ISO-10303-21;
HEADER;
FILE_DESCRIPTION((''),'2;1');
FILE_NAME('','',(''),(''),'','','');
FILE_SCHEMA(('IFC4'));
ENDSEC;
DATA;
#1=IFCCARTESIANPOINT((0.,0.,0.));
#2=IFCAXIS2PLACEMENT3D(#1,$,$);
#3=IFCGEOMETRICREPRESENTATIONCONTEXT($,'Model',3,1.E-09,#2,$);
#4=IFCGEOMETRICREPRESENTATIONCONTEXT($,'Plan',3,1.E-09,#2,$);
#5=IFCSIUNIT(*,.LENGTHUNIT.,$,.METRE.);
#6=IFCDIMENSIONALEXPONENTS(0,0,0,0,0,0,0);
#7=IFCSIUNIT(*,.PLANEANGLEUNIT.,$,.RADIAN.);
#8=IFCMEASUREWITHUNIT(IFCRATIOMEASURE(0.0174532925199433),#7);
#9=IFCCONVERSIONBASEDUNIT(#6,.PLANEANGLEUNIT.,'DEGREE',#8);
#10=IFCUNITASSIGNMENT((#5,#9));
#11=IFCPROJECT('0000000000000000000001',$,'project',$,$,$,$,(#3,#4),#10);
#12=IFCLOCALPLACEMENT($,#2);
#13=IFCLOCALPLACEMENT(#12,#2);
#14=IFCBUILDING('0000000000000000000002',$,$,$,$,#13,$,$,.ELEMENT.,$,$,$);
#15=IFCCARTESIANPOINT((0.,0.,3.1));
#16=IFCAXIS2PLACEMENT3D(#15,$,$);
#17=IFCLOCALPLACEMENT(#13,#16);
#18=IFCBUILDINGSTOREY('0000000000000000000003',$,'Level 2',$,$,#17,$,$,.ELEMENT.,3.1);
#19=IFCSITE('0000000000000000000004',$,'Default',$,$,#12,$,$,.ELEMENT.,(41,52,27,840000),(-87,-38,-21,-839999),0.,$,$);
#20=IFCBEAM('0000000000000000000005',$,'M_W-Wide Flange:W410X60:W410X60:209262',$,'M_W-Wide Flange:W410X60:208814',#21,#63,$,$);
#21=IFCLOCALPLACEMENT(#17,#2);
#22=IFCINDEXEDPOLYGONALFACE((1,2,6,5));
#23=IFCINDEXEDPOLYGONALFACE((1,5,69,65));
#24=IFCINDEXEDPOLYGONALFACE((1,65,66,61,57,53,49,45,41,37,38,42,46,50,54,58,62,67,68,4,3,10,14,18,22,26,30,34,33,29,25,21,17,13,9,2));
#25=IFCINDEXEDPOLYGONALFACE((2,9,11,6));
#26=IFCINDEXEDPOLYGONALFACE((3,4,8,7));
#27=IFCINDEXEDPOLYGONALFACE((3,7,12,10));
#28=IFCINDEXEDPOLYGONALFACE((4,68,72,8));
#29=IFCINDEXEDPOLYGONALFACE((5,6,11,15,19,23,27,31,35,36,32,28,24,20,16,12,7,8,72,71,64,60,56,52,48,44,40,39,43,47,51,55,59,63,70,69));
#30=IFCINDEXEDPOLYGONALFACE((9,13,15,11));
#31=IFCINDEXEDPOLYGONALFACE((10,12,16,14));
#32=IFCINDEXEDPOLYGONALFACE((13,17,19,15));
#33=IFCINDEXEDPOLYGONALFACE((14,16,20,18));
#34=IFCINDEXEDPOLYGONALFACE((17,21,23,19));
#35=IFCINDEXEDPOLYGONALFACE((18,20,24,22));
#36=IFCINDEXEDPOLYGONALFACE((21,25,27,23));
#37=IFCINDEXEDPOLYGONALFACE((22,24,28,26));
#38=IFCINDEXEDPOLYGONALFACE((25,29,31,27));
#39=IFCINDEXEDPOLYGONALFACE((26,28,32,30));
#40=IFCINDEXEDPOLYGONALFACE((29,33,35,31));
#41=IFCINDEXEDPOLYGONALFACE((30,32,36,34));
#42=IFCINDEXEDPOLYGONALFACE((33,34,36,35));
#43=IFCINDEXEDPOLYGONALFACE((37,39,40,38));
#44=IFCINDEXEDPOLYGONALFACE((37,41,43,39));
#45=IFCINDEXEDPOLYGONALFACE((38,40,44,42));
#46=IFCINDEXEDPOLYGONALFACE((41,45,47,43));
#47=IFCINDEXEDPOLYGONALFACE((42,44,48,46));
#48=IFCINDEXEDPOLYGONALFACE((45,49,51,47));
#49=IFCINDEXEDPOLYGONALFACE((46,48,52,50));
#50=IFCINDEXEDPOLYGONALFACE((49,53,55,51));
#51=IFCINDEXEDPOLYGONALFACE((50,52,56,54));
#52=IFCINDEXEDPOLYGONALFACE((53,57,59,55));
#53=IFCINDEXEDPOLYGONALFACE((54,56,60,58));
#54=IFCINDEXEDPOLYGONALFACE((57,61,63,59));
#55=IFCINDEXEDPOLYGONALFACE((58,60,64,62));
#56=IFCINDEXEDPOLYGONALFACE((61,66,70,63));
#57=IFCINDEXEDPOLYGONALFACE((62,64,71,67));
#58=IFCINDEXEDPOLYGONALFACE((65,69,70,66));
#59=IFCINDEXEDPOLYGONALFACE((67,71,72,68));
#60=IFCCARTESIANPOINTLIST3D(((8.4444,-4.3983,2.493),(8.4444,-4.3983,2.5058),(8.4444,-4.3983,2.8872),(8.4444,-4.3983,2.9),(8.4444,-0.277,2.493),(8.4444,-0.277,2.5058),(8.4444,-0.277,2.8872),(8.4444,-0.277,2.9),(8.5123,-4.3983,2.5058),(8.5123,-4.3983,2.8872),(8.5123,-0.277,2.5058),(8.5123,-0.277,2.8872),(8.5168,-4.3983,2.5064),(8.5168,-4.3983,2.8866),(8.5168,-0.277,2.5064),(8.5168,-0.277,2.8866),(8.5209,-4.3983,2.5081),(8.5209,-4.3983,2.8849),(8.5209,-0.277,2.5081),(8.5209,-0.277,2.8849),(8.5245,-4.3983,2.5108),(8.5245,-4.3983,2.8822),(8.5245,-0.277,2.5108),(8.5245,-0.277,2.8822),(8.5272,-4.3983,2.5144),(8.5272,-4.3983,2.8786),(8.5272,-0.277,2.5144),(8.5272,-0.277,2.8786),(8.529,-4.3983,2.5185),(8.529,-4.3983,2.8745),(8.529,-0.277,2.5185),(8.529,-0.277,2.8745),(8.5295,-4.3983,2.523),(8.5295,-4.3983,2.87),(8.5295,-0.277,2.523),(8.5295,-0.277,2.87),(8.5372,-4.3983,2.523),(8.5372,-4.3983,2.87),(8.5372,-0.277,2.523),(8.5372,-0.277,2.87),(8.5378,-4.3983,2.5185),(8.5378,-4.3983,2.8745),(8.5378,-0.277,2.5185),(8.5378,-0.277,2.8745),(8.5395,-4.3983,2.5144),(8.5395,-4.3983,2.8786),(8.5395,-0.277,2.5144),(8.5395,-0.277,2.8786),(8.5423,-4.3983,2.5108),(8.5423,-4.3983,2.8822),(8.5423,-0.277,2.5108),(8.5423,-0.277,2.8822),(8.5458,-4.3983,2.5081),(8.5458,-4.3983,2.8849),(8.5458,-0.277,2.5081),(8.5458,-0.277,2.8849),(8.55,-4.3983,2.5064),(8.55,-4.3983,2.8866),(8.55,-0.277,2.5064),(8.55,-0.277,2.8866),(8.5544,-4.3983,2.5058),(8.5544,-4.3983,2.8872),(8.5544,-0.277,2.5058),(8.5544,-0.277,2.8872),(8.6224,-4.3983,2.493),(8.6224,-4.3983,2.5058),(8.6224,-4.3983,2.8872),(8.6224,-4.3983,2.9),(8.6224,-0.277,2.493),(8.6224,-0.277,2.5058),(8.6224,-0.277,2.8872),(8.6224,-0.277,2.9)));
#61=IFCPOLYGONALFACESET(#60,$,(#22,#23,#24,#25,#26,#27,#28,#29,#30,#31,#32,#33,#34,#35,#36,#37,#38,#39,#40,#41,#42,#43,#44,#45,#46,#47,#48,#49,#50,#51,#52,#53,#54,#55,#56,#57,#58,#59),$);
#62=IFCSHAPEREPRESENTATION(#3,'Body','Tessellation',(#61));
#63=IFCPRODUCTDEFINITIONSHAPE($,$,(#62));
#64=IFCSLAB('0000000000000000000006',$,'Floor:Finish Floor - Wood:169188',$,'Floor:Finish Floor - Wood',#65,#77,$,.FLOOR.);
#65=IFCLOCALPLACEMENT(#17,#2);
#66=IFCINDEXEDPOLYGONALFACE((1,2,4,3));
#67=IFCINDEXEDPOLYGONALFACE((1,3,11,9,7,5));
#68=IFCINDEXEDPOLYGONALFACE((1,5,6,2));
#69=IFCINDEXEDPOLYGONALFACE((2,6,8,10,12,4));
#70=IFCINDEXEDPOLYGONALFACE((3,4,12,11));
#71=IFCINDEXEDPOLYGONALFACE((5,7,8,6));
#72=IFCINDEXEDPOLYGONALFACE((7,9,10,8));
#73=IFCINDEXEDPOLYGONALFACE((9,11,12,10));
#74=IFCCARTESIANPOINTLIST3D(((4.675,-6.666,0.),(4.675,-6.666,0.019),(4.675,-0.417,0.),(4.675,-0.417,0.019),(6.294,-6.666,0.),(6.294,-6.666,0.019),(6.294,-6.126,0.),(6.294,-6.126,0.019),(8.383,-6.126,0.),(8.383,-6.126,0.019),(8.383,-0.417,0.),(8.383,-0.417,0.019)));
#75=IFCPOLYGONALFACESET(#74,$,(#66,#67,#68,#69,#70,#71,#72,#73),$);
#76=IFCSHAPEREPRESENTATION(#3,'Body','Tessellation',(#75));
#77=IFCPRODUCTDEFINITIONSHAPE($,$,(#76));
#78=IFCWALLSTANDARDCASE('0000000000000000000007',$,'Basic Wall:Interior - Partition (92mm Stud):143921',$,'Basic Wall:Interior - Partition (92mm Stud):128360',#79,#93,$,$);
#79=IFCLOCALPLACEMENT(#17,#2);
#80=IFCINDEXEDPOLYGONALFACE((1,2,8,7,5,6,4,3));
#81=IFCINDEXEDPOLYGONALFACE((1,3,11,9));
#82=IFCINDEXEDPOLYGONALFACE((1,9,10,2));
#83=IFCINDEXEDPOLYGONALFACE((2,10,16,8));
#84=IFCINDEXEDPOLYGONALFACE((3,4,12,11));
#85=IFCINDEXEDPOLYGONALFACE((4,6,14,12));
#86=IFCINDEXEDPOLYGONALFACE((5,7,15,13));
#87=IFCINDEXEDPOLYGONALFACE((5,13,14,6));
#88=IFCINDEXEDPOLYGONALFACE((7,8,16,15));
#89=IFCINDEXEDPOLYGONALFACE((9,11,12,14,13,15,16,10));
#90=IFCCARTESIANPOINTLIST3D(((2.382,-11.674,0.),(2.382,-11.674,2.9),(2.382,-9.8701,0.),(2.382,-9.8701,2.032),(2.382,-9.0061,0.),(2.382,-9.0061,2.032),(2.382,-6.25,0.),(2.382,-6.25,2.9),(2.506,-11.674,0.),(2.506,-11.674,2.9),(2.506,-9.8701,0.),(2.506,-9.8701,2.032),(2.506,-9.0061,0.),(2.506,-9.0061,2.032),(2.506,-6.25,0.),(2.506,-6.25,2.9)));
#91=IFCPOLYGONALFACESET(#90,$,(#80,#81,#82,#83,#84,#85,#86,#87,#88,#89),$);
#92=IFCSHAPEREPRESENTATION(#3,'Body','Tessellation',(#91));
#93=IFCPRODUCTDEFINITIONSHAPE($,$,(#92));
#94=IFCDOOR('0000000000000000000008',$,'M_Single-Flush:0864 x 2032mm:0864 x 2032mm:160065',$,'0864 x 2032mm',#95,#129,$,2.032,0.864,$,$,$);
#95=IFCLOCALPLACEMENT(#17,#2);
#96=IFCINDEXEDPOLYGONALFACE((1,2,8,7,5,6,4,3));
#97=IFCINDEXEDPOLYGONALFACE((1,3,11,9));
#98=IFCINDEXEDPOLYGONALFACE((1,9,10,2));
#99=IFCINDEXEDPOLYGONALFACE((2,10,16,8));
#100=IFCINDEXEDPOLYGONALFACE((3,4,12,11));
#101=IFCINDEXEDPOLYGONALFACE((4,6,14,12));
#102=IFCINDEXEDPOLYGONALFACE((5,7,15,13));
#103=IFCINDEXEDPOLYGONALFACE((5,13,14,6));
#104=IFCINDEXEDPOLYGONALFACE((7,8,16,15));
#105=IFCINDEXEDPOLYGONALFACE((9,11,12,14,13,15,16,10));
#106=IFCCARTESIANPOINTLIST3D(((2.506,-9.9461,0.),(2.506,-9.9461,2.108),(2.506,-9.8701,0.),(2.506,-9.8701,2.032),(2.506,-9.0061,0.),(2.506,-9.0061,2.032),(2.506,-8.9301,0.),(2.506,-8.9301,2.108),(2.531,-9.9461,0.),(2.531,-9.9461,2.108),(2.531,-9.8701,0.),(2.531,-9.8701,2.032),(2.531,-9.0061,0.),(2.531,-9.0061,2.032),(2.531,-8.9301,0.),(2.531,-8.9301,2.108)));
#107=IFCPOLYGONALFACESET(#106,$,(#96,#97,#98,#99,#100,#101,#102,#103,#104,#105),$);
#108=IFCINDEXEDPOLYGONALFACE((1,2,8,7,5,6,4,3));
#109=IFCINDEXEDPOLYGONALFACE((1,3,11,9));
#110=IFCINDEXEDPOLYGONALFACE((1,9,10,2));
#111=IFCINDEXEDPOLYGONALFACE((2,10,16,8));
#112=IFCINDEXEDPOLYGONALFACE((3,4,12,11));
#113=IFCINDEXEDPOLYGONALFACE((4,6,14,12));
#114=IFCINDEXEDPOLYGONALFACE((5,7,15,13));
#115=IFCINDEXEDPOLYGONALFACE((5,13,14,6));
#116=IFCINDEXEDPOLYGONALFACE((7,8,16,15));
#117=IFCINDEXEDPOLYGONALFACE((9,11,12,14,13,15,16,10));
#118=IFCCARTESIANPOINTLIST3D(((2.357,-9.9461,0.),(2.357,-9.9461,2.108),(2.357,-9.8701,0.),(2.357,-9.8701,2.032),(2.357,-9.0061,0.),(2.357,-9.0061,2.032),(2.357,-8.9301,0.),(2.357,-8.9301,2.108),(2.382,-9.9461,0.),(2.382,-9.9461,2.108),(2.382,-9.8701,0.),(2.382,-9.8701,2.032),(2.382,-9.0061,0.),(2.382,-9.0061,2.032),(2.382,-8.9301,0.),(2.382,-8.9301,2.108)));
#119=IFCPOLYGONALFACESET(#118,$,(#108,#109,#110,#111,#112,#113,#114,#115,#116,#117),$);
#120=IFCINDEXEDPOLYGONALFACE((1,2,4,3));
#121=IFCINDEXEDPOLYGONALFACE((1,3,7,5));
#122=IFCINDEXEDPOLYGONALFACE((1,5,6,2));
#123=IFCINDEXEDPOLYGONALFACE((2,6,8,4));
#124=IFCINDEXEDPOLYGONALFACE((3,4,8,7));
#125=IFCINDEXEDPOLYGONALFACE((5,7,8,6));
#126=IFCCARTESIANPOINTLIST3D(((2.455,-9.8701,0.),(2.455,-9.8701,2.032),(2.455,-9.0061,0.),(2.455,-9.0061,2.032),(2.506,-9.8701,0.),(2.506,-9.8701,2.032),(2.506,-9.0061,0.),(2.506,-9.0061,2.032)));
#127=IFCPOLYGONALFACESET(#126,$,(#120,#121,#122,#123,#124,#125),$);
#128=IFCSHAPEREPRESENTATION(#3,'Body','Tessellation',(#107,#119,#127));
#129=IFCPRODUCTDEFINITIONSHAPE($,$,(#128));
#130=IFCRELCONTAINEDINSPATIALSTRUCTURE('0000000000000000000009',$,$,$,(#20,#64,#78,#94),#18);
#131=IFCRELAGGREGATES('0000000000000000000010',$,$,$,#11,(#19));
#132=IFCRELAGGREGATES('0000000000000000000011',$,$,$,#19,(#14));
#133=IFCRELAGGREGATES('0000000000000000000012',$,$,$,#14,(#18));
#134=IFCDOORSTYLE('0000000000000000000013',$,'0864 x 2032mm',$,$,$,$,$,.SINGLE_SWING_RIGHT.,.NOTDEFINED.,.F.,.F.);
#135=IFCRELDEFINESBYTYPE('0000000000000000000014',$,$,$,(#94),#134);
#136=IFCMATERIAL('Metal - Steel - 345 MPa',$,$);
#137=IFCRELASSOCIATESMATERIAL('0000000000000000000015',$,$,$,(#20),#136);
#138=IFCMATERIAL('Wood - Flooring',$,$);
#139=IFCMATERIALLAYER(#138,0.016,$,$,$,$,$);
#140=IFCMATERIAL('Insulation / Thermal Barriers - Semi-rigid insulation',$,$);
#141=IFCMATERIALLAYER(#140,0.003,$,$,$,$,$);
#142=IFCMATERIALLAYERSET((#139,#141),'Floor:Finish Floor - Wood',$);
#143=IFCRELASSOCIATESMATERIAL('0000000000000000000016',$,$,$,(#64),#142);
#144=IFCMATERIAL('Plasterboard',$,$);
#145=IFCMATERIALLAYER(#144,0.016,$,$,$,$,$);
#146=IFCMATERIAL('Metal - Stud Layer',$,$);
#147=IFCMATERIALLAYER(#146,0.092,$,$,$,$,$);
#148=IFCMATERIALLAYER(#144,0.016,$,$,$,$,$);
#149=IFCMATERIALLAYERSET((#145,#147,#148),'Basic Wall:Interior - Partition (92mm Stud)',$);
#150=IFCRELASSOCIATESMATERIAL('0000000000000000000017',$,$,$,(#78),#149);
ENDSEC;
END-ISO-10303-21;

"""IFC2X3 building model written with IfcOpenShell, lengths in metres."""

from ifc_helpers import new_model, entity, si_unit, converted_unit, frame, frame_2d, origin, origin_2d_with_axis, place, context, project, spatial, polyline, circle_curve, parameter, trimmed, segment, composite_curve, rectangle, outline, extrude, source, transform, mapped, material, layer, layer_set, layer_usage, type_object, type_shapes, element, fill, save


model = new_model("IFC2X3")

# Units and contexts
model_context = context("Model", 3, precision=1e-09, world=origin())
plan_context = context("Plan", 3, precision=1e-09, world=origin())
ifc_project = project(units=[si_unit("LENGTHUNIT", "METRE"), converted_unit("PLANEANGLEUNIT", "DEGREE", entity("IfcRatioMeasure", 0.0174532925199433), si_unit("PLANEANGLEUNIT", "RADIAN"), dimensions=[0, 0, 0, 0, 0, 0, 0])], contexts=[model_context, plan_context])

# Site, building, storey
site_placement = place(None, origin())
site = spatial("IfcSite", under=ifc_project, at=site_placement, Name="Default", CompositionType="ELEMENT", RefLatitude=(41, 52, 27, 840000), RefLongitude=(-87, -38, -21, -839999), RefElevation=0.0)
building_placement = place(site_placement, origin())
building = spatial("IfcBuilding", under=site, at=building_placement, CompositionType="ELEMENT")
storey_placement = place(building_placement, frame((0.0, 0.0, 3.1)))
storey = spatial("IfcBuildingStorey", under=building, at=storey_placement, Name="Level 2", CompositionType="ELEMENT", Elevation=3.1)

# Beam
ifc_material_1 = material(Name="Metal - Steel - 345 MPa")
beam_1_placement = place(storey_placement, frame((8.5334, -4.3983, 2.9)))
element("IfcBeam", 1, at=beam_1_placement, inside=storey, material=ifc_material_1, Name="M_W-Wide Flange:W410X60:W410X60:209262", ObjectType="M_W-Wide Flange:W410X60:208814", context=model_context, shape_type="SweptSolid", body=[
    extrude(outline(composite_curve([segment(polyline([(-0.089, -0.1907), (-0.089, -0.2035)]), True, "CONTINUOUS"), segment(polyline([(-0.089, -0.2035), (0.089, -0.2035)]), True, "CONTINUOUS"), segment(polyline([(0.089, -0.2035), (0.089, -0.1907)]), True, "CONTINUOUS"), segment(polyline([(0.089, -0.1907), (0.021, -0.1907)]), True, "CONTINUOUS"), segment(trimmed(circle_curve(frame_2d((0.021, -0.1735), x_axis=(0.0, -1.0)), 0.0172), [parameter(270.0)], [parameter(360.0)], True, "PARAMETER"), False, "CONTINUOUS"), segment(polyline([(0.0038, -0.1735), (0.0038, 0.1735)]), True, "CONTINUOUS"), segment(trimmed(circle_curve(frame_2d((0.021, 0.1735), x_axis=(-1.0, 0.0)), 0.0172), [parameter(270.0)], [parameter(360.0)], True, "PARAMETER"), False, "CONTINUOUS"), segment(polyline([(0.021, 0.1907), (0.089, 0.1907)]), True, "CONTINUOUS"), segment(polyline([(0.089, 0.1907), (0.089, 0.2035)]), True, "CONTINUOUS"), segment(polyline([(0.089, 0.2035), (-0.089, 0.2035)]), True, "CONTINUOUS"), segment(polyline([(-0.089, 0.2035), (-0.089, 0.1907)]), True, "CONTINUOUS"), segment(polyline([(-0.089, 0.1907), (-0.0211, 0.1907)]), True, "CONTINUOUS"), segment(trimmed(circle_curve(frame_2d((-0.0211, 0.1735), x_axis=(0.0, 1.0)), 0.0172), [parameter(270.0)], [parameter(0.0)], True, "PARAMETER"), False, "CONTINUOUS"), segment(polyline([(-0.0039, 0.1735), (-0.0039, -0.1735)]), True, "CONTINUOUS"), segment(trimmed(circle_curve(frame_2d((-0.0211, -0.1735), x_axis=(1.0, 0.0)), 0.0172), [parameter(270.0)], [parameter(0.0)], True, "PARAMETER"), False, "CONTINUOUS"), segment(polyline([(-0.0211, -0.1907), (-0.089, -0.1907)]), True, "CONTINUOUS")], self_intersect=False)), frame((0.0, 0.0, -0.2035), z_axis=(0.0, -1.0, 0.0), x_axis=(1.0, 0.0, 0.0)), (0.0, 0.0, -1.0), 4.1213),
])

# Slab
ifc_material_2 = material(Name="Wood - Flooring")
ifc_layer_1 = layer(ifc_material_2, 0.016)
ifc_material_3 = material(Name="Insulation / Thermal Barriers - Semi-rigid insulation")
ifc_layer_2 = layer(ifc_material_3, 0.003)
ifc_layer_set_1 = layer_set([ifc_layer_1, ifc_layer_2], Name="Floor:Finish Floor - Wood")
ifc_layer_usage_1 = layer_usage(ifc_layer_set_1, "AXIS3", "POSITIVE", 0.0)
slab_placement = place(storey_placement, frame((4.675, -6.666, 0.0)))
element("IfcSlab", 2, at=slab_placement, inside=storey, material=ifc_layer_usage_1, Name="Floor:Finish Floor - Wood:169188", ObjectType="Floor:Finish Floor - Wood", PredefinedType="FLOOR", context=model_context, shape_type="SweptSolid", body=[
    extrude(outline(polyline([(-1.854, 3.1245), (-1.854, -2.5845), (0.235, -2.5845), (0.235, -3.1245), (1.854, -3.1245), (1.854, 3.1245), (-1.854, 3.1245)])), frame((1.854, 3.1245, 0.019), z_axis=(0.0, 0.0, -1.0), x_axis=(-1.0, 0.0, 0.0)), (0.0, 0.0, 1.0), 0.019),
])

# Wall, opening, door
ifc_material_4 = material(Name="Plasterboard")
ifc_layer_3 = layer(ifc_material_4, 0.016)
ifc_material_5 = material(Name="Metal - Stud Layer")
ifc_layer_4 = layer(ifc_material_5, 0.092)
ifc_layer_5 = layer(ifc_material_4, 0.016)
ifc_layer_set_2 = layer_set([ifc_layer_3, ifc_layer_4, ifc_layer_5], Name="Basic Wall:Interior - Partition (92mm Stud)")
ifc_layer_usage_2 = layer_usage(ifc_layer_set_2, "AXIS2", "NEGATIVE", 0.062)
wall_1_placement = place(storey_placement, frame((2.444, -6.25, 0.0), z_axis=(0.0, 0.0, 1.0), x_axis=(0.0, -1.0, 0.0)))
wall_1 = element("IfcWallStandardCase", 3, at=wall_1_placement, inside=storey, material=ifc_layer_usage_2, Name="Basic Wall:Interior - Partition (92mm Stud):143921", ObjectType="Basic Wall:Interior - Partition (92mm Stud):128360", context=model_context, shape_type="SweptSolid", body=[
    extrude(rectangle(XDim=5.424, YDim=0.124, at=frame_2d((2.712, 0.0), x_axis=(-1.0, 0.0))), origin(), (0.0, 0.0, 1.0), 2.9),
])
opening_1_placement = place(wall_1_placement, frame((2.7561, -0.062, 0.0)))
opening_1 = element("IfcOpeningElement", 4, at=opening_1_placement, cuts=wall_1, ObjectType="Opening", context=model_context, shape_type="SweptSolid", body=[
    extrude(rectangle(XDim=0.864, YDim=2.032, at=frame_2d((1.016, 0.432), x_axis=(0.0, 1.0))), frame((0.0, 0.0, 0.0), z_axis=(0.0, 1.0, 0.0), x_axis=(0.0, 0.0, 1.0)), (0.0, 0.0, 1.0), 0.124),
])
door_style_1 = type_object("IfcDoorStyle", Name="0864 x 2032mm", ConstructionType="NOTDEFINED", OperationType="SINGLE_SWING_RIGHT", ParameterTakesPrecedence=False, Sizeable=False)
shared_shape_1 = source(origin(), model_context, "Body", "SweptSolid", [
    extrude(outline(polyline([(-0.508, -1.073), (0.508, -1.073), (0.508, 1.035), (0.432, 1.035), (0.432, -0.997), (-0.432, -0.997), (-0.432, 1.035), (-0.508, 1.035), (-0.508, -1.073)])), frame((0.432, 0.124, 1.035), z_axis=(0.0, 1.0, 0.0), x_axis=(1.0, 0.0, 0.0)), (0.0, 0.0, 1.0), 0.025),
    extrude(outline(polyline([(-1.073, -0.508), (1.035, -0.508), (1.035, -0.432), (-0.997, -0.432), (-0.997, 0.432), (1.035, 0.432), (1.035, 0.508), (-1.073, 0.508), (-1.073, -0.508)])), frame((0.432, -0.025, 1.035), z_axis=(0.0, 1.0, 0.0), x_axis=(0.0, 0.0, -1.0)), (0.0, 0.0, 1.0), 0.025),
    extrude(rectangle(XDim=0.051, YDim=0.864, at=origin_2d_with_axis()), frame((0.432, 0.0985, 0.0), z_axis=(0.0, 0.0, 1.0), x_axis=(0.0, 1.0, 0.0)), (0.0, 0.0, 1.0), 2.032),
])
type_shapes(door_style_1, [shared_shape_1])
door_1_placement = place(opening_1_placement, origin())
door_1 = element("IfcDoor", 5, at=door_1_placement, inside=storey, type_object=door_style_1, Name="M_Single-Flush:0864 x 2032mm:0864 x 2032mm:160065", ObjectType="0864 x 2032mm", OverallHeight=2.032, OverallWidth=0.864, context=model_context, shape_type="MappedRepresentation", body=[
    mapped(shared_shape_1, transform((0.0, 0.0, 0.0), scale=1.0)),
])
fill(opening_1, door_1)

save(model, "model.ifc")
